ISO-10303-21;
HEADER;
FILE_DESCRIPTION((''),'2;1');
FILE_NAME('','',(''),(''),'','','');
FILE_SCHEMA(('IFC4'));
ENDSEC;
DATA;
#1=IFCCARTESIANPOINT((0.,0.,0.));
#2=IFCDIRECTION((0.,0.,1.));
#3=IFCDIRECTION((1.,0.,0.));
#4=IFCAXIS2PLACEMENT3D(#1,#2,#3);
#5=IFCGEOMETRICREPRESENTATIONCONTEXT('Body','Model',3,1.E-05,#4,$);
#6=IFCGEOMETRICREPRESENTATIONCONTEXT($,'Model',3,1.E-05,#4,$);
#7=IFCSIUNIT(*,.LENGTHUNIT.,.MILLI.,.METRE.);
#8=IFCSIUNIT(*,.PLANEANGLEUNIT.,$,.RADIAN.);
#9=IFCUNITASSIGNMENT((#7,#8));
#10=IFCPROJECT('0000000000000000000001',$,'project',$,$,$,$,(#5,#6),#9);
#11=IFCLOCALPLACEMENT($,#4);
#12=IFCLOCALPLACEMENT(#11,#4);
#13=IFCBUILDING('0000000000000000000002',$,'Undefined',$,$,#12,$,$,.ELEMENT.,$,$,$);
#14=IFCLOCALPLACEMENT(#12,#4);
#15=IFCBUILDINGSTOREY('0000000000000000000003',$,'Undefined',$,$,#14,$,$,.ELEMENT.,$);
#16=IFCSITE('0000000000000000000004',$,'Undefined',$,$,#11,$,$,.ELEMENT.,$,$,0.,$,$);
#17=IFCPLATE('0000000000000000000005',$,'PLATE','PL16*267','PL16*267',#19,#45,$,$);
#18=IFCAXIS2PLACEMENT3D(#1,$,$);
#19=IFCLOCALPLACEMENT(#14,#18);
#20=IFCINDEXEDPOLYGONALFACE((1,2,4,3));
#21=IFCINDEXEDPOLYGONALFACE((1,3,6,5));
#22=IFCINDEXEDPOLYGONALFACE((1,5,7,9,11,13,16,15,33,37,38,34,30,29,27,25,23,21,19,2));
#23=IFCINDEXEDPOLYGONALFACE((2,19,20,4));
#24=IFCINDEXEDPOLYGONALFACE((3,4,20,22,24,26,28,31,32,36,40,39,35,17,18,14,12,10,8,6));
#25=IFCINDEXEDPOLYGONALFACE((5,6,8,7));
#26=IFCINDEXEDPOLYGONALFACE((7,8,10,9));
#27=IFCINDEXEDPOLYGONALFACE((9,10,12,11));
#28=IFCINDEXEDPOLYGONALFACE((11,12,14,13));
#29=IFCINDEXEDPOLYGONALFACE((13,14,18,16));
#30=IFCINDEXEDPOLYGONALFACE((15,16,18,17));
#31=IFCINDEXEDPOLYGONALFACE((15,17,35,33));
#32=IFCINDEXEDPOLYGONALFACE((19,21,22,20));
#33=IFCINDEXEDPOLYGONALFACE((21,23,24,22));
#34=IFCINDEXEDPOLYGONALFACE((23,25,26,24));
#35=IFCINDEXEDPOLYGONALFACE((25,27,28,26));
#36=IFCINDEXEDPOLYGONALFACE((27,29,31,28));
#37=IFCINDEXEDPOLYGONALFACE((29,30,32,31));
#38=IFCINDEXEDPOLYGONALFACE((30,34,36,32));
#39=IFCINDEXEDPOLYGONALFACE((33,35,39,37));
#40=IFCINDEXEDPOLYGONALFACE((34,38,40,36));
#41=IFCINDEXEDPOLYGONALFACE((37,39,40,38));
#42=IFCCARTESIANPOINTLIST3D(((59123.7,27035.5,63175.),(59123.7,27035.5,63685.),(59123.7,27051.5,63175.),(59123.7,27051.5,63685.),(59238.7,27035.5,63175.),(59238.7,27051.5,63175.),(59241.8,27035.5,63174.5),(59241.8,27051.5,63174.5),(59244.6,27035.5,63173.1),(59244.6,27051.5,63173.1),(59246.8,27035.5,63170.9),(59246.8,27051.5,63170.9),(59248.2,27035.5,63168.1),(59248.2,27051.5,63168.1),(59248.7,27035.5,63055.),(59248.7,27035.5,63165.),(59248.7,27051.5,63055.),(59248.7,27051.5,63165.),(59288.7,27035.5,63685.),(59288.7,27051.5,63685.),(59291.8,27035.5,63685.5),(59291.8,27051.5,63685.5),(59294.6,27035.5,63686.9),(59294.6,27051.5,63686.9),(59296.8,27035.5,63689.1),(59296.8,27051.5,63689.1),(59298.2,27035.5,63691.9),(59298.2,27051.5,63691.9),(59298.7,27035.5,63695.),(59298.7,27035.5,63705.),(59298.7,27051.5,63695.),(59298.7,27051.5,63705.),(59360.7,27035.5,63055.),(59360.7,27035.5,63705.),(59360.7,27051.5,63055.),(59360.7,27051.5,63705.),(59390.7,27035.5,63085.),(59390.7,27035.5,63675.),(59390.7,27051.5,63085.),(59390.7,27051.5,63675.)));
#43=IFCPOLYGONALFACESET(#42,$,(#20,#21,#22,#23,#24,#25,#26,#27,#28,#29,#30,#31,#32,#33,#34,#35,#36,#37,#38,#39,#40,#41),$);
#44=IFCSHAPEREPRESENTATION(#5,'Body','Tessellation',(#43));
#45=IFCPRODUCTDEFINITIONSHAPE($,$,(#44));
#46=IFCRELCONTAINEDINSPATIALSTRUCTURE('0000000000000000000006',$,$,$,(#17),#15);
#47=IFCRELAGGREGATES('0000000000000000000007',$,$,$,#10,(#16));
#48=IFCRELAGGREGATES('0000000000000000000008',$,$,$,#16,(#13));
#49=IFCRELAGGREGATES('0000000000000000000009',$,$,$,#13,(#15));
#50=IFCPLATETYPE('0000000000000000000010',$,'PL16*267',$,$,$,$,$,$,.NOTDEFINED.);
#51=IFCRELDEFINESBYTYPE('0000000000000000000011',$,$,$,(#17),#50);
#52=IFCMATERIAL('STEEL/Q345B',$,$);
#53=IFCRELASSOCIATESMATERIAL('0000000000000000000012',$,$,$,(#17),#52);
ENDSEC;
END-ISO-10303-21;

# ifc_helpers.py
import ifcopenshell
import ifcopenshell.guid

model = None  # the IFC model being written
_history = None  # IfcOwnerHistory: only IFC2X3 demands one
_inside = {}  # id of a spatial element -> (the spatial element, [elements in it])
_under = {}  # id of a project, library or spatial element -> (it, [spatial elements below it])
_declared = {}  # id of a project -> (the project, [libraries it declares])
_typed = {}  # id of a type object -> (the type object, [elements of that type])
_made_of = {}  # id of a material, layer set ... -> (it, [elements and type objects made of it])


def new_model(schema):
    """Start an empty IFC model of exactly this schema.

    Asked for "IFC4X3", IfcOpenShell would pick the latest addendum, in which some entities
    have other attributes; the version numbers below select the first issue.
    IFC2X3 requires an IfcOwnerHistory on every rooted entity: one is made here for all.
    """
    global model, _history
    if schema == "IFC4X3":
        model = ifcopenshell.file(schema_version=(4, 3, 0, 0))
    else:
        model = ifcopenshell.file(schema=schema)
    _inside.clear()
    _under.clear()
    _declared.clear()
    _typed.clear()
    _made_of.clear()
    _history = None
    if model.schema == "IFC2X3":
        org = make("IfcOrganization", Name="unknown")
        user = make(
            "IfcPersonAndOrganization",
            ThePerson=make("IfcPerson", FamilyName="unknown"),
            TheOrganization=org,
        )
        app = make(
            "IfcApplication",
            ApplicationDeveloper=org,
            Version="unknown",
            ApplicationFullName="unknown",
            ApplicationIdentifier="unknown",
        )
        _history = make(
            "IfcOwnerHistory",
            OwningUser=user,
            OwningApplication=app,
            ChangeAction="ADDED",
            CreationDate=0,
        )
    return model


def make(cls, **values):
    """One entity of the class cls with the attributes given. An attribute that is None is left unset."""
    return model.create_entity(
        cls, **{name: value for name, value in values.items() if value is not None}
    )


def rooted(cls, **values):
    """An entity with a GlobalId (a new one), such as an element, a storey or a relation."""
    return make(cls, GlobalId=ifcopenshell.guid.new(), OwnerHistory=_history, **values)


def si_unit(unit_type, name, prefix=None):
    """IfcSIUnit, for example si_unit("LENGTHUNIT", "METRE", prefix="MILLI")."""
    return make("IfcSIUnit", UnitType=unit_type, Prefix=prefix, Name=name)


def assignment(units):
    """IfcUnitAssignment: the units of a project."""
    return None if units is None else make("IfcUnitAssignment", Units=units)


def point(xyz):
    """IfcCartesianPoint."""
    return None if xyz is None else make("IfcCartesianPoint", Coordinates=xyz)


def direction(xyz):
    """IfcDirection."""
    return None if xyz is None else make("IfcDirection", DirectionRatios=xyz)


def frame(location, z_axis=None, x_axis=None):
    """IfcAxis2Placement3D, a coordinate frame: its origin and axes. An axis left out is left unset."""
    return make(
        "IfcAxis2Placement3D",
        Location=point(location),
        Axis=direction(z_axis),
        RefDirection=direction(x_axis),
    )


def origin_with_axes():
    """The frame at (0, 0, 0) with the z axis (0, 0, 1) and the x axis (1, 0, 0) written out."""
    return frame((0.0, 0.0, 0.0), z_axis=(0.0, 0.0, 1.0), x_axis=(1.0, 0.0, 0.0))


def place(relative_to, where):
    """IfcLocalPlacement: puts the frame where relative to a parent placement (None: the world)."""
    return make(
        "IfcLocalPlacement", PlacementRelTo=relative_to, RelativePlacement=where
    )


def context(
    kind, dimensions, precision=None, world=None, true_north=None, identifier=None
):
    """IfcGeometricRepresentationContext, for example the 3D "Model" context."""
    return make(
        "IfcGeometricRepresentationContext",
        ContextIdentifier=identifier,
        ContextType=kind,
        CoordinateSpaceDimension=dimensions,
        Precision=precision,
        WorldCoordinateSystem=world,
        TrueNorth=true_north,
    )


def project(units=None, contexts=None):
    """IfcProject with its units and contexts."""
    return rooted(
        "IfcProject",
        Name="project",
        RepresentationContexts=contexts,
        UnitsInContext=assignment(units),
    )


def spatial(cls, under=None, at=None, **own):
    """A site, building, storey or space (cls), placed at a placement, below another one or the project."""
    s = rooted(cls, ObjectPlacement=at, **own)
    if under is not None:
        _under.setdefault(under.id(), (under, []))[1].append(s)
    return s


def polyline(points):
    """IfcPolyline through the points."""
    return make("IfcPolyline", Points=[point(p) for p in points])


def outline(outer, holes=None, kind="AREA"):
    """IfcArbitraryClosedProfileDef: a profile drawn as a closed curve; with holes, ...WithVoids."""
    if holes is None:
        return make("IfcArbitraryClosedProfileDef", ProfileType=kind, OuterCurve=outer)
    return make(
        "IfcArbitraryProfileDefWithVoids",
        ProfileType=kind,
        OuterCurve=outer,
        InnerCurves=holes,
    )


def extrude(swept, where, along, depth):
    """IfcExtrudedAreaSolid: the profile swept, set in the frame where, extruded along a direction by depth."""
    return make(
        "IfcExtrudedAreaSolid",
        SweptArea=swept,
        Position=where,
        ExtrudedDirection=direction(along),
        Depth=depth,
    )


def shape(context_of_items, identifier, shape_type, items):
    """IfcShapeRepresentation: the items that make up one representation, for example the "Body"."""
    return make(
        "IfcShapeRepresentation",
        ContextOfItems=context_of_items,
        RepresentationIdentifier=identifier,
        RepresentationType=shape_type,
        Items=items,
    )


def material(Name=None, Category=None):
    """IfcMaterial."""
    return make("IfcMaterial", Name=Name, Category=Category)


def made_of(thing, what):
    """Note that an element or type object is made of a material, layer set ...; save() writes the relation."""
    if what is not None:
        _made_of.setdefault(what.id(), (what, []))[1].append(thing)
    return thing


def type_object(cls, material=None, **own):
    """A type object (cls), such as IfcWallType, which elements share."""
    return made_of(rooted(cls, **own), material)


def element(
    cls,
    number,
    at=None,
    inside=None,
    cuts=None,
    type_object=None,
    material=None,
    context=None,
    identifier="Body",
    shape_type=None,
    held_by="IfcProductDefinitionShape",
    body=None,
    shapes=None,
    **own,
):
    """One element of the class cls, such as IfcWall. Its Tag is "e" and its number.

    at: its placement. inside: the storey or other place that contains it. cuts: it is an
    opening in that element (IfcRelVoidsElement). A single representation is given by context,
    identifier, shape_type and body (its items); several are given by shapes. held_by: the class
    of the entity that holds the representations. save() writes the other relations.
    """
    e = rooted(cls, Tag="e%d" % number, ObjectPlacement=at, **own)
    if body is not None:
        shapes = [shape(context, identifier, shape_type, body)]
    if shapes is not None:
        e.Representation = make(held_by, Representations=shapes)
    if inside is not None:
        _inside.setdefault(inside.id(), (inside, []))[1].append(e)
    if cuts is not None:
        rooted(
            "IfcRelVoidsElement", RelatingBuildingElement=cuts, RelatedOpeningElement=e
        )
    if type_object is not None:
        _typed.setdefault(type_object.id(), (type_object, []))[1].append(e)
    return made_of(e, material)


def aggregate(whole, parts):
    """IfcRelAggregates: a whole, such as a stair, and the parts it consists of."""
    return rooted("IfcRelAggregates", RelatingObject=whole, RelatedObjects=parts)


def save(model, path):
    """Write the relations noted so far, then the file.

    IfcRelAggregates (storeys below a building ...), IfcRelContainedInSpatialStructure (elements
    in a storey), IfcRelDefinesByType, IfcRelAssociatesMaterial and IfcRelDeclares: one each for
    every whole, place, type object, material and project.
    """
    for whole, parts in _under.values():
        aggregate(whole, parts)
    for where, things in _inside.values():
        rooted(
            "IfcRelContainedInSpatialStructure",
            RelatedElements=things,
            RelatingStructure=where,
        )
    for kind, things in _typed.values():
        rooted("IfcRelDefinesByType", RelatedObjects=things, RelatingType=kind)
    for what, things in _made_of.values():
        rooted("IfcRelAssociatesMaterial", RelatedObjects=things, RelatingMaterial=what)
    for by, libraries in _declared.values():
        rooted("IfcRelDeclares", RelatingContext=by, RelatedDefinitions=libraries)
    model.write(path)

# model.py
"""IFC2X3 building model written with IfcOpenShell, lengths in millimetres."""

from ifc_helpers import new_model, si_unit, frame, origin_with_axes, place, context, project, spatial, polyline, outline, extrude, material, type_object, element, save


model = new_model("IFC2X3")

# Units and contexts
model_context_1 = context("Model", 3, precision=1e-05, world=origin_with_axes(), identifier="Body")
model_context_2 = context("Model", 3, precision=1e-05, world=origin_with_axes())
ifc_project = project(units=[si_unit("LENGTHUNIT", "METRE", prefix="MILLI"), si_unit("PLANEANGLEUNIT", "RADIAN")], contexts=[model_context_1, model_context_2])

# Site, building, storey
site_placement = place(None, origin_with_axes())
site = spatial("IfcSite", under=ifc_project, at=site_placement, Name="Undefined", CompositionType="ELEMENT", RefElevation=0.0)
building_placement = place(site_placement, origin_with_axes())
building = spatial("IfcBuilding", under=site, at=building_placement, Name="Undefined", CompositionType="ELEMENT")
storey_placement = place(building_placement, origin_with_axes())
storey = spatial("IfcBuildingStorey", under=building, at=storey_placement, Name="Undefined", CompositionType="ELEMENT")

# Shared definitions
ifc_material_1 = material(Name="STEEL/Q345B")

# Plate
plate_type_1 = type_object("IfcPlateType", Name="PL16*267", PredefinedType="NOTDEFINED")
plate_1_placement = place(storey_placement, frame((59390.7, 27043.5, 63085.0), z_axis=(0.0, 1.0, 0.0), x_axis=(-0.707107, 0.0, -0.707107)))
element("IfcPlate", 1, at=plate_1_placement, inside=storey, type_object=plate_type_1, material=ifc_material_1, Name="PLATE", Description="PL16*267", ObjectType="PL16*267", context=model_context_1, shape_type="SweptSolid", body=[
    extrude(outline(polyline([(0.0, 0.0), (42.4, 0.0), (121.6, 79.2), (43.8, 157.0), (42.0, 159.5), (41.0, 162.5), (41.0, 165.6), (42.0, 168.6), (43.8, 171.1), (125.2, 252.4), (-235.5, 613.1), (-352.1, 496.4), (-354.7, 494.5), (-357.6, 493.6), (-360.8, 493.6), (-363.8, 494.5), (-366.3, 496.4), (-373.4, 503.5), (-417.2, 459.6), (-417.2, 417.2), (0.0, 0.0)])), frame((0.0, 0.0, -8.0), z_axis=(0.0, 0.0, 1.0), x_axis=(1.0, 0.0, 0.0)), (0.0, 0.0, 1.0), 16.0),
])

save(model, "model.ifc")
